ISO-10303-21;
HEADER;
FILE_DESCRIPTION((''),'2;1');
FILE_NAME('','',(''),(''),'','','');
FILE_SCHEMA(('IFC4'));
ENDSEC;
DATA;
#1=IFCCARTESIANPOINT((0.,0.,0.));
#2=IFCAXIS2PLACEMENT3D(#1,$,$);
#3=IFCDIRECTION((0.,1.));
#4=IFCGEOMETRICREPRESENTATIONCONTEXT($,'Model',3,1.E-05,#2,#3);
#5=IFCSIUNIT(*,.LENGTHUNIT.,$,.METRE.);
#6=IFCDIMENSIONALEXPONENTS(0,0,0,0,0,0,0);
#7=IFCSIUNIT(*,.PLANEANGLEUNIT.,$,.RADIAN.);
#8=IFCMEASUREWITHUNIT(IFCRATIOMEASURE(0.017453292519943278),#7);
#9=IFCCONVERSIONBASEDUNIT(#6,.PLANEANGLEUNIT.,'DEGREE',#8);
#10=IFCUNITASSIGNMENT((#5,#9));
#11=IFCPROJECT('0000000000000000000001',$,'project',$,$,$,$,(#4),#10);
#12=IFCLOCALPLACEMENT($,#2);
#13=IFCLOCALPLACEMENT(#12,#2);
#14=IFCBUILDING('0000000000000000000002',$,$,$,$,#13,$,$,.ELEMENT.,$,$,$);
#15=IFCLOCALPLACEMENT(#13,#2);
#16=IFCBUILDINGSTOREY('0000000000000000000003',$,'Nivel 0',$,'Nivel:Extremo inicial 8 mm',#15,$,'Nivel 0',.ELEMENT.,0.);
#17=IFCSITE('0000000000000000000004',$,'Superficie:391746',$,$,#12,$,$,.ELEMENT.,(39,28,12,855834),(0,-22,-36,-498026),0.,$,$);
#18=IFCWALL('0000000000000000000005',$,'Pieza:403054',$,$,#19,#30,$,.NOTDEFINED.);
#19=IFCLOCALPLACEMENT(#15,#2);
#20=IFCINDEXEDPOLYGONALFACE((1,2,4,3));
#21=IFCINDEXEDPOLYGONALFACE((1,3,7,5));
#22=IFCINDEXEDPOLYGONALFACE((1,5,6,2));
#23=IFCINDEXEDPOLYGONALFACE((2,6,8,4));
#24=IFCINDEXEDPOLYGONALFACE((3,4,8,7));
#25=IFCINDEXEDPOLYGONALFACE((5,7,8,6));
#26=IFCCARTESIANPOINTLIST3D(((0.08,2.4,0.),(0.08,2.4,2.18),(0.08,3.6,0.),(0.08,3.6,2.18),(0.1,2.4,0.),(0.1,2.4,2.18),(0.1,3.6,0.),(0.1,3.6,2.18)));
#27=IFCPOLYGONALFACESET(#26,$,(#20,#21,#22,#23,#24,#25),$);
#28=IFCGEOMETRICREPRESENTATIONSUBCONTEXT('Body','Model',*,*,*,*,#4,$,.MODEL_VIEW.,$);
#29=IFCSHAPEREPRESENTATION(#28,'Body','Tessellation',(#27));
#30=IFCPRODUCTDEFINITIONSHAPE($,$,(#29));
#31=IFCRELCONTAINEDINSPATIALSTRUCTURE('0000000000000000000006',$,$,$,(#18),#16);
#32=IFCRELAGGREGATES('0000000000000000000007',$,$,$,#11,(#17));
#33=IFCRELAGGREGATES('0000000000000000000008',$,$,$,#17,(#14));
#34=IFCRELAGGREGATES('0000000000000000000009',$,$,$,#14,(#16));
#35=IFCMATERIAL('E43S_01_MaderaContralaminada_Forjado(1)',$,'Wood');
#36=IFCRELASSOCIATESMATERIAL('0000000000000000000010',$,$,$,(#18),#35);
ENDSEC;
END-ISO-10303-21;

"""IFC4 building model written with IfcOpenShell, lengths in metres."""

from ifc_helpers import new_model, entity, si_unit, converted_unit, direction, frame, frame_2d, origin, place, context, subcontext, project, spatial, rectangle, extrude, material, element, save


model = new_model("IFC4")

# Units and contexts
model_context = context("Model", 3, precision=1e-05, world=origin(), true_north=direction((0.0, 1.0)))
body_context = subcontext(model_context, "Body", "Model", "MODEL_VIEW")
ifc_project = project(units=[si_unit("LENGTHUNIT", "METRE"), converted_unit("PLANEANGLEUNIT", "DEGREE", entity("IfcRatioMeasure", 0.017453292519943278), si_unit("PLANEANGLEUNIT", "RADIAN"), dimensions=[0, 0, 0, 0, 0, 0, 0])], contexts=[model_context])

# Site, building, storey
site_placement = place(None, origin())
site = spatial("IfcSite", under=ifc_project, at=site_placement, Name="Superficie:391746", CompositionType="ELEMENT", RefLatitude=(39, 28, 12, 855834), RefLongitude=(0, -22, -36, -498026), RefElevation=0.0)
building_placement = place(site_placement, origin())
building = spatial("IfcBuilding", under=site, at=building_placement, CompositionType="ELEMENT")
storey_placement = place(building_placement, origin())
storey = spatial("IfcBuildingStorey", under=building, at=storey_placement, Name="Nivel 0", ObjectType="Nivel:Extremo inicial 8 mm", LongName="Nivel 0", CompositionType="ELEMENT", Elevation=0.0)

# Shared definitions
ifc_material_1 = material(Name="E43S_01_MaderaContralaminada_Forjado(1)", Category="Wood")

# Wall
wall_1_placement = place(storey_placement, frame((0.08, 2.4, 0.0)))
element("IfcWall", 1, at=wall_1_placement, inside=storey, material=ifc_material_1, Name="Pieza:403054", PredefinedType="NOTDEFINED", context=body_context, shape_type="SweptSolid", body=[
    extrude(rectangle(XDim=0.02, YDim=1.2, at=frame_2d((0.0, 0.0), x_axis=(1.0, 0.0))), frame((0.01, 0.6, 0.0), z_axis=(0.0, 0.0, 1.0), x_axis=(-1.0, 0.0, 0.0)), (0.0, 0.0, 1.0), 2.18),
])

save(model, "model.ifc")
